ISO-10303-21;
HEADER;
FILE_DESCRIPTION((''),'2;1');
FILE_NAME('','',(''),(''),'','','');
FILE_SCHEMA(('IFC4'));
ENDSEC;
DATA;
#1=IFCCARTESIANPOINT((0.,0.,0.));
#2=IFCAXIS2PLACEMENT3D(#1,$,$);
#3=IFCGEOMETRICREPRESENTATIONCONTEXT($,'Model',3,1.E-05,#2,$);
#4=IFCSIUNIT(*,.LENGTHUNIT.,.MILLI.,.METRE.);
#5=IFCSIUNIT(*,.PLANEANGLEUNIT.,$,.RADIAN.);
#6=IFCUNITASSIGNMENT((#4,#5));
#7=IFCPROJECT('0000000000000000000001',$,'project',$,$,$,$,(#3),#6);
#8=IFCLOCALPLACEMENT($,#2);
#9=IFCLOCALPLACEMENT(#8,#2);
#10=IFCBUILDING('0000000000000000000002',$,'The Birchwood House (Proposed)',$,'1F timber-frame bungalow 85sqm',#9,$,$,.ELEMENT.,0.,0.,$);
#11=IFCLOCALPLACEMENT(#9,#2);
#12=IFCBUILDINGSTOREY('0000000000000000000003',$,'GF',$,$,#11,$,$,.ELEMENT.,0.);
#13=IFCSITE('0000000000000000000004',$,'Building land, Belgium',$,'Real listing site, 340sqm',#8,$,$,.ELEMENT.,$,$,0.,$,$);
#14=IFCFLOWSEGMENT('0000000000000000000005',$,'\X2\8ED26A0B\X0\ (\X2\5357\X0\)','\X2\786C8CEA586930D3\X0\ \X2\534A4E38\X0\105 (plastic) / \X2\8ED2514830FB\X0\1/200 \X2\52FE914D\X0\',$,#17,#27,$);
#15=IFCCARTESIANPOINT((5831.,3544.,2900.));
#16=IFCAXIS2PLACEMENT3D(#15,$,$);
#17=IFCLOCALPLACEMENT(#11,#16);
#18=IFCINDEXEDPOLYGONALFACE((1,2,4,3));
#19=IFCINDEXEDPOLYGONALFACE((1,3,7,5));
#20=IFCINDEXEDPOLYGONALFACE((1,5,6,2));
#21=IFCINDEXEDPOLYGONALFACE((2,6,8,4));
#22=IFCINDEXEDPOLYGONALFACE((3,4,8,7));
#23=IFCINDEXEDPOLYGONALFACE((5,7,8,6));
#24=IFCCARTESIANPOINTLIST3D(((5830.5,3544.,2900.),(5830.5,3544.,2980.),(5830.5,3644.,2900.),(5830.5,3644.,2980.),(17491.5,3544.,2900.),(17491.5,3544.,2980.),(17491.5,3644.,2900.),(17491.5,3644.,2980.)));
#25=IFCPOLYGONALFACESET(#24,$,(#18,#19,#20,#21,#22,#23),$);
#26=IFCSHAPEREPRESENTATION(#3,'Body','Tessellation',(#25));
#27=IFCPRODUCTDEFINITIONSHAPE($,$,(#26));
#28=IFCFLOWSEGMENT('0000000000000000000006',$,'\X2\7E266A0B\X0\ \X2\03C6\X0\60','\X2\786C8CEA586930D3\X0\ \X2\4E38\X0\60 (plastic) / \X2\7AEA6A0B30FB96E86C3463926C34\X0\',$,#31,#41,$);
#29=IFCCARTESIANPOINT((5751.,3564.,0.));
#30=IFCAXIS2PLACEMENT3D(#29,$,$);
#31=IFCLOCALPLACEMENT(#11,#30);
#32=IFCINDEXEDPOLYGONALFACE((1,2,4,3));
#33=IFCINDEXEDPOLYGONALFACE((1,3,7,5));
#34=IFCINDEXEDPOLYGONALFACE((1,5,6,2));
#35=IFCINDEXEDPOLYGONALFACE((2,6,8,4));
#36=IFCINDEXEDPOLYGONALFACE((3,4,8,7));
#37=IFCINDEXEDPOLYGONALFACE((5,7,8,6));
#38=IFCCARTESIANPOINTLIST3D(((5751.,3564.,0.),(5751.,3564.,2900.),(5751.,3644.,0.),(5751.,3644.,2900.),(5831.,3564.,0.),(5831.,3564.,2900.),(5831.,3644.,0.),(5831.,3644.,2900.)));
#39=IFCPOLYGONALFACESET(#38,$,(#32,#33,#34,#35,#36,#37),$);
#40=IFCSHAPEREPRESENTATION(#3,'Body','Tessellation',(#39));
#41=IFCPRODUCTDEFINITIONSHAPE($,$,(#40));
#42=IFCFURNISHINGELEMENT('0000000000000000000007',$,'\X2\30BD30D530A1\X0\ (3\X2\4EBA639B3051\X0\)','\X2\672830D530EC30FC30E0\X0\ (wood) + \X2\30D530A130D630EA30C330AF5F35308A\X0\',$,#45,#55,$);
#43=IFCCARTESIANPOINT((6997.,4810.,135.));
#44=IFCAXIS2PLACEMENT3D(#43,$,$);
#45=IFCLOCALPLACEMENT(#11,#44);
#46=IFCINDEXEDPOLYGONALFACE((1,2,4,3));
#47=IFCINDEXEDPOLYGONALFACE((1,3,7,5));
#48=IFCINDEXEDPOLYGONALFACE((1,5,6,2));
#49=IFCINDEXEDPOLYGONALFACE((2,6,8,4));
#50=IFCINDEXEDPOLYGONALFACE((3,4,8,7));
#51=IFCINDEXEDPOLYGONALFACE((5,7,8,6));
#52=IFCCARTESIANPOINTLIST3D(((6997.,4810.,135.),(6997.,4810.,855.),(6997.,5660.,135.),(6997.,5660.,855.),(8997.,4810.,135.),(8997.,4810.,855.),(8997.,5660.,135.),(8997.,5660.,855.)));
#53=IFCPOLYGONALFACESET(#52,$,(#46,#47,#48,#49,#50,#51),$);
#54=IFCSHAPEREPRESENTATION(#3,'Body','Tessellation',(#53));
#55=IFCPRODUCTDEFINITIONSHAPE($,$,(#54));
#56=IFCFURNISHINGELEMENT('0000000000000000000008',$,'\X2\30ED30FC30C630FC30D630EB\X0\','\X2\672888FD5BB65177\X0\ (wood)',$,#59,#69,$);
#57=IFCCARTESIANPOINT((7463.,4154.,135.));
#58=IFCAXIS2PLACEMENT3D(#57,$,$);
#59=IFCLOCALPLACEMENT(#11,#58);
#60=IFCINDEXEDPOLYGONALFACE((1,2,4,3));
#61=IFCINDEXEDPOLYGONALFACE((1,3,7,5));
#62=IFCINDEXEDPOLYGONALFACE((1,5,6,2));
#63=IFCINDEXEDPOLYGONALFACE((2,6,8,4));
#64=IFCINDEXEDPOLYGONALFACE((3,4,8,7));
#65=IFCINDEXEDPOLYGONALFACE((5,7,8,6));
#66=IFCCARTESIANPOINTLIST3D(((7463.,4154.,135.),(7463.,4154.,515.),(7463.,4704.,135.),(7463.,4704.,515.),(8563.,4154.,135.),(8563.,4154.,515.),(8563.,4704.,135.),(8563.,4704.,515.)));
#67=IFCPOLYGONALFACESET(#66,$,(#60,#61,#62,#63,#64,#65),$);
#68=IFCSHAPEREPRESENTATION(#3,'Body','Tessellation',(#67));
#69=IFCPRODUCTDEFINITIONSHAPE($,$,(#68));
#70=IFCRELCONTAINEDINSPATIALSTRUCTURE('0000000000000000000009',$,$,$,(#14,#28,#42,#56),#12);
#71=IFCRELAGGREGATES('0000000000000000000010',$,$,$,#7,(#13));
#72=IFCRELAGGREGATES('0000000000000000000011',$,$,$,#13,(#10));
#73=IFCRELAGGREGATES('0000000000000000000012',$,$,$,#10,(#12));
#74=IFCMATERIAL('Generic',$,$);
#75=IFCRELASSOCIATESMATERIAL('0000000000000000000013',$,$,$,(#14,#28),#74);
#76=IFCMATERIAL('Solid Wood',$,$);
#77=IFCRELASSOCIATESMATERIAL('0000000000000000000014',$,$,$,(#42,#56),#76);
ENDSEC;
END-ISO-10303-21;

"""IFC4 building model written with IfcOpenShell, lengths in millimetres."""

from ifc_helpers import new_model, si_unit, frame, frame_2d, origin, place, context, project, spatial, rectangle, extrude, material, element, save


model = new_model("IFC4")

# Units and contexts
model_context = context("Model", 3, precision=1e-05, world=origin())
ifc_project = project(units=[si_unit("LENGTHUNIT", "METRE", prefix="MILLI"), si_unit("PLANEANGLEUNIT", "RADIAN")], contexts=[model_context])

# Site, building, storey
site_placement = place(None, origin())
site = spatial("IfcSite", under=ifc_project, at=site_placement, Name="Building land, Belgium", ObjectType="Real listing site, 340sqm", CompositionType="ELEMENT", RefElevation=0.0)
building_placement = place(site_placement, origin())
building = spatial("IfcBuilding", under=site, at=building_placement, Name="The Birchwood House (Proposed)", ObjectType="1F timber-frame bungalow 85sqm", CompositionType="ELEMENT", ElevationOfRefHeight=0.0, ElevationOfTerrain=0.0)
storey_placement = place(building_placement, origin())
storey = spatial("IfcBuildingStorey", under=building, at=storey_placement, Name="GF", CompositionType="ELEMENT", Elevation=0.0)

# Shared definitions
ifc_material_1 = material(Name="Solid Wood")

# Shared definitions
ifc_material_2 = material(Name="Generic")

# Flow segments
flow_segment_1_placement = place(storey_placement, frame((5831.0, 3544.0, 2900.0)))
element("IfcFlowSegment", 1, at=flow_segment_1_placement, inside=storey, material=ifc_material_2, Name="軒樋 (南)", Description="硬質塩ビ 半丸105 (plastic) / 軒先・1/200 勾配", context=model_context, shape_type="SweptSolid", body=[
    extrude(rectangle(XDim=11661.0, YDim=100.0, at=frame_2d((5830.0, 50.0))), frame((5831.0, 3544.0, 2900.0)), (0.0, 0.0, 1.0), 80.0),
])
flow_segment_2_placement = place(storey_placement, frame((5751.0, 3564.0, 0.0)))
element("IfcFlowSegment", 2, at=flow_segment_2_placement, inside=storey, material=ifc_material_2, Name="縦樋 φ60", Description="硬質塩ビ 丸60 (plastic) / 竪樋・雨水排水", context=model_context, shape_type="SweptSolid", body=[
    extrude(rectangle(XDim=80.0, YDim=80.0, at=frame_2d((40.0, 40.0))), frame((5751.0, 3564.0, 0.0)), (0.0, 0.0, 1.0), 2900.0),
])

# Furnishing elements
furnishing_1_placement = place(storey_placement, frame((6997.0, 4810.0, 135.0)))
element("IfcFurnishingElement", 3, at=furnishing_1_placement, inside=storey, material=ifc_material_1, Name="ソファ (3人掛け)", Description="木フレーム (wood) + ファブリック張り", context=model_context, shape_type="SweptSolid", body=[
    extrude(rectangle(XDim=2000.0, YDim=850.0, at=frame_2d((1000.0, 425.0))), frame((6997.0, 4810.0, 135.0)), (0.0, 0.0, 1.0), 720.0),
])
furnishing_2_placement = place(storey_placement, frame((7463.0, 4154.0, 135.0)))
element("IfcFurnishingElement", 4, at=furnishing_2_placement, inside=storey, material=ifc_material_1, Name="ローテーブル", Description="木製家具 (wood)", context=model_context, shape_type="SweptSolid", body=[
    extrude(rectangle(XDim=1100.0, YDim=550.0, at=frame_2d((550.0, 275.0))), frame((7463.0, 4154.0, 135.0)), (0.0, 0.0, 1.0), 380.0),
])

save(model, "model.ifc")
